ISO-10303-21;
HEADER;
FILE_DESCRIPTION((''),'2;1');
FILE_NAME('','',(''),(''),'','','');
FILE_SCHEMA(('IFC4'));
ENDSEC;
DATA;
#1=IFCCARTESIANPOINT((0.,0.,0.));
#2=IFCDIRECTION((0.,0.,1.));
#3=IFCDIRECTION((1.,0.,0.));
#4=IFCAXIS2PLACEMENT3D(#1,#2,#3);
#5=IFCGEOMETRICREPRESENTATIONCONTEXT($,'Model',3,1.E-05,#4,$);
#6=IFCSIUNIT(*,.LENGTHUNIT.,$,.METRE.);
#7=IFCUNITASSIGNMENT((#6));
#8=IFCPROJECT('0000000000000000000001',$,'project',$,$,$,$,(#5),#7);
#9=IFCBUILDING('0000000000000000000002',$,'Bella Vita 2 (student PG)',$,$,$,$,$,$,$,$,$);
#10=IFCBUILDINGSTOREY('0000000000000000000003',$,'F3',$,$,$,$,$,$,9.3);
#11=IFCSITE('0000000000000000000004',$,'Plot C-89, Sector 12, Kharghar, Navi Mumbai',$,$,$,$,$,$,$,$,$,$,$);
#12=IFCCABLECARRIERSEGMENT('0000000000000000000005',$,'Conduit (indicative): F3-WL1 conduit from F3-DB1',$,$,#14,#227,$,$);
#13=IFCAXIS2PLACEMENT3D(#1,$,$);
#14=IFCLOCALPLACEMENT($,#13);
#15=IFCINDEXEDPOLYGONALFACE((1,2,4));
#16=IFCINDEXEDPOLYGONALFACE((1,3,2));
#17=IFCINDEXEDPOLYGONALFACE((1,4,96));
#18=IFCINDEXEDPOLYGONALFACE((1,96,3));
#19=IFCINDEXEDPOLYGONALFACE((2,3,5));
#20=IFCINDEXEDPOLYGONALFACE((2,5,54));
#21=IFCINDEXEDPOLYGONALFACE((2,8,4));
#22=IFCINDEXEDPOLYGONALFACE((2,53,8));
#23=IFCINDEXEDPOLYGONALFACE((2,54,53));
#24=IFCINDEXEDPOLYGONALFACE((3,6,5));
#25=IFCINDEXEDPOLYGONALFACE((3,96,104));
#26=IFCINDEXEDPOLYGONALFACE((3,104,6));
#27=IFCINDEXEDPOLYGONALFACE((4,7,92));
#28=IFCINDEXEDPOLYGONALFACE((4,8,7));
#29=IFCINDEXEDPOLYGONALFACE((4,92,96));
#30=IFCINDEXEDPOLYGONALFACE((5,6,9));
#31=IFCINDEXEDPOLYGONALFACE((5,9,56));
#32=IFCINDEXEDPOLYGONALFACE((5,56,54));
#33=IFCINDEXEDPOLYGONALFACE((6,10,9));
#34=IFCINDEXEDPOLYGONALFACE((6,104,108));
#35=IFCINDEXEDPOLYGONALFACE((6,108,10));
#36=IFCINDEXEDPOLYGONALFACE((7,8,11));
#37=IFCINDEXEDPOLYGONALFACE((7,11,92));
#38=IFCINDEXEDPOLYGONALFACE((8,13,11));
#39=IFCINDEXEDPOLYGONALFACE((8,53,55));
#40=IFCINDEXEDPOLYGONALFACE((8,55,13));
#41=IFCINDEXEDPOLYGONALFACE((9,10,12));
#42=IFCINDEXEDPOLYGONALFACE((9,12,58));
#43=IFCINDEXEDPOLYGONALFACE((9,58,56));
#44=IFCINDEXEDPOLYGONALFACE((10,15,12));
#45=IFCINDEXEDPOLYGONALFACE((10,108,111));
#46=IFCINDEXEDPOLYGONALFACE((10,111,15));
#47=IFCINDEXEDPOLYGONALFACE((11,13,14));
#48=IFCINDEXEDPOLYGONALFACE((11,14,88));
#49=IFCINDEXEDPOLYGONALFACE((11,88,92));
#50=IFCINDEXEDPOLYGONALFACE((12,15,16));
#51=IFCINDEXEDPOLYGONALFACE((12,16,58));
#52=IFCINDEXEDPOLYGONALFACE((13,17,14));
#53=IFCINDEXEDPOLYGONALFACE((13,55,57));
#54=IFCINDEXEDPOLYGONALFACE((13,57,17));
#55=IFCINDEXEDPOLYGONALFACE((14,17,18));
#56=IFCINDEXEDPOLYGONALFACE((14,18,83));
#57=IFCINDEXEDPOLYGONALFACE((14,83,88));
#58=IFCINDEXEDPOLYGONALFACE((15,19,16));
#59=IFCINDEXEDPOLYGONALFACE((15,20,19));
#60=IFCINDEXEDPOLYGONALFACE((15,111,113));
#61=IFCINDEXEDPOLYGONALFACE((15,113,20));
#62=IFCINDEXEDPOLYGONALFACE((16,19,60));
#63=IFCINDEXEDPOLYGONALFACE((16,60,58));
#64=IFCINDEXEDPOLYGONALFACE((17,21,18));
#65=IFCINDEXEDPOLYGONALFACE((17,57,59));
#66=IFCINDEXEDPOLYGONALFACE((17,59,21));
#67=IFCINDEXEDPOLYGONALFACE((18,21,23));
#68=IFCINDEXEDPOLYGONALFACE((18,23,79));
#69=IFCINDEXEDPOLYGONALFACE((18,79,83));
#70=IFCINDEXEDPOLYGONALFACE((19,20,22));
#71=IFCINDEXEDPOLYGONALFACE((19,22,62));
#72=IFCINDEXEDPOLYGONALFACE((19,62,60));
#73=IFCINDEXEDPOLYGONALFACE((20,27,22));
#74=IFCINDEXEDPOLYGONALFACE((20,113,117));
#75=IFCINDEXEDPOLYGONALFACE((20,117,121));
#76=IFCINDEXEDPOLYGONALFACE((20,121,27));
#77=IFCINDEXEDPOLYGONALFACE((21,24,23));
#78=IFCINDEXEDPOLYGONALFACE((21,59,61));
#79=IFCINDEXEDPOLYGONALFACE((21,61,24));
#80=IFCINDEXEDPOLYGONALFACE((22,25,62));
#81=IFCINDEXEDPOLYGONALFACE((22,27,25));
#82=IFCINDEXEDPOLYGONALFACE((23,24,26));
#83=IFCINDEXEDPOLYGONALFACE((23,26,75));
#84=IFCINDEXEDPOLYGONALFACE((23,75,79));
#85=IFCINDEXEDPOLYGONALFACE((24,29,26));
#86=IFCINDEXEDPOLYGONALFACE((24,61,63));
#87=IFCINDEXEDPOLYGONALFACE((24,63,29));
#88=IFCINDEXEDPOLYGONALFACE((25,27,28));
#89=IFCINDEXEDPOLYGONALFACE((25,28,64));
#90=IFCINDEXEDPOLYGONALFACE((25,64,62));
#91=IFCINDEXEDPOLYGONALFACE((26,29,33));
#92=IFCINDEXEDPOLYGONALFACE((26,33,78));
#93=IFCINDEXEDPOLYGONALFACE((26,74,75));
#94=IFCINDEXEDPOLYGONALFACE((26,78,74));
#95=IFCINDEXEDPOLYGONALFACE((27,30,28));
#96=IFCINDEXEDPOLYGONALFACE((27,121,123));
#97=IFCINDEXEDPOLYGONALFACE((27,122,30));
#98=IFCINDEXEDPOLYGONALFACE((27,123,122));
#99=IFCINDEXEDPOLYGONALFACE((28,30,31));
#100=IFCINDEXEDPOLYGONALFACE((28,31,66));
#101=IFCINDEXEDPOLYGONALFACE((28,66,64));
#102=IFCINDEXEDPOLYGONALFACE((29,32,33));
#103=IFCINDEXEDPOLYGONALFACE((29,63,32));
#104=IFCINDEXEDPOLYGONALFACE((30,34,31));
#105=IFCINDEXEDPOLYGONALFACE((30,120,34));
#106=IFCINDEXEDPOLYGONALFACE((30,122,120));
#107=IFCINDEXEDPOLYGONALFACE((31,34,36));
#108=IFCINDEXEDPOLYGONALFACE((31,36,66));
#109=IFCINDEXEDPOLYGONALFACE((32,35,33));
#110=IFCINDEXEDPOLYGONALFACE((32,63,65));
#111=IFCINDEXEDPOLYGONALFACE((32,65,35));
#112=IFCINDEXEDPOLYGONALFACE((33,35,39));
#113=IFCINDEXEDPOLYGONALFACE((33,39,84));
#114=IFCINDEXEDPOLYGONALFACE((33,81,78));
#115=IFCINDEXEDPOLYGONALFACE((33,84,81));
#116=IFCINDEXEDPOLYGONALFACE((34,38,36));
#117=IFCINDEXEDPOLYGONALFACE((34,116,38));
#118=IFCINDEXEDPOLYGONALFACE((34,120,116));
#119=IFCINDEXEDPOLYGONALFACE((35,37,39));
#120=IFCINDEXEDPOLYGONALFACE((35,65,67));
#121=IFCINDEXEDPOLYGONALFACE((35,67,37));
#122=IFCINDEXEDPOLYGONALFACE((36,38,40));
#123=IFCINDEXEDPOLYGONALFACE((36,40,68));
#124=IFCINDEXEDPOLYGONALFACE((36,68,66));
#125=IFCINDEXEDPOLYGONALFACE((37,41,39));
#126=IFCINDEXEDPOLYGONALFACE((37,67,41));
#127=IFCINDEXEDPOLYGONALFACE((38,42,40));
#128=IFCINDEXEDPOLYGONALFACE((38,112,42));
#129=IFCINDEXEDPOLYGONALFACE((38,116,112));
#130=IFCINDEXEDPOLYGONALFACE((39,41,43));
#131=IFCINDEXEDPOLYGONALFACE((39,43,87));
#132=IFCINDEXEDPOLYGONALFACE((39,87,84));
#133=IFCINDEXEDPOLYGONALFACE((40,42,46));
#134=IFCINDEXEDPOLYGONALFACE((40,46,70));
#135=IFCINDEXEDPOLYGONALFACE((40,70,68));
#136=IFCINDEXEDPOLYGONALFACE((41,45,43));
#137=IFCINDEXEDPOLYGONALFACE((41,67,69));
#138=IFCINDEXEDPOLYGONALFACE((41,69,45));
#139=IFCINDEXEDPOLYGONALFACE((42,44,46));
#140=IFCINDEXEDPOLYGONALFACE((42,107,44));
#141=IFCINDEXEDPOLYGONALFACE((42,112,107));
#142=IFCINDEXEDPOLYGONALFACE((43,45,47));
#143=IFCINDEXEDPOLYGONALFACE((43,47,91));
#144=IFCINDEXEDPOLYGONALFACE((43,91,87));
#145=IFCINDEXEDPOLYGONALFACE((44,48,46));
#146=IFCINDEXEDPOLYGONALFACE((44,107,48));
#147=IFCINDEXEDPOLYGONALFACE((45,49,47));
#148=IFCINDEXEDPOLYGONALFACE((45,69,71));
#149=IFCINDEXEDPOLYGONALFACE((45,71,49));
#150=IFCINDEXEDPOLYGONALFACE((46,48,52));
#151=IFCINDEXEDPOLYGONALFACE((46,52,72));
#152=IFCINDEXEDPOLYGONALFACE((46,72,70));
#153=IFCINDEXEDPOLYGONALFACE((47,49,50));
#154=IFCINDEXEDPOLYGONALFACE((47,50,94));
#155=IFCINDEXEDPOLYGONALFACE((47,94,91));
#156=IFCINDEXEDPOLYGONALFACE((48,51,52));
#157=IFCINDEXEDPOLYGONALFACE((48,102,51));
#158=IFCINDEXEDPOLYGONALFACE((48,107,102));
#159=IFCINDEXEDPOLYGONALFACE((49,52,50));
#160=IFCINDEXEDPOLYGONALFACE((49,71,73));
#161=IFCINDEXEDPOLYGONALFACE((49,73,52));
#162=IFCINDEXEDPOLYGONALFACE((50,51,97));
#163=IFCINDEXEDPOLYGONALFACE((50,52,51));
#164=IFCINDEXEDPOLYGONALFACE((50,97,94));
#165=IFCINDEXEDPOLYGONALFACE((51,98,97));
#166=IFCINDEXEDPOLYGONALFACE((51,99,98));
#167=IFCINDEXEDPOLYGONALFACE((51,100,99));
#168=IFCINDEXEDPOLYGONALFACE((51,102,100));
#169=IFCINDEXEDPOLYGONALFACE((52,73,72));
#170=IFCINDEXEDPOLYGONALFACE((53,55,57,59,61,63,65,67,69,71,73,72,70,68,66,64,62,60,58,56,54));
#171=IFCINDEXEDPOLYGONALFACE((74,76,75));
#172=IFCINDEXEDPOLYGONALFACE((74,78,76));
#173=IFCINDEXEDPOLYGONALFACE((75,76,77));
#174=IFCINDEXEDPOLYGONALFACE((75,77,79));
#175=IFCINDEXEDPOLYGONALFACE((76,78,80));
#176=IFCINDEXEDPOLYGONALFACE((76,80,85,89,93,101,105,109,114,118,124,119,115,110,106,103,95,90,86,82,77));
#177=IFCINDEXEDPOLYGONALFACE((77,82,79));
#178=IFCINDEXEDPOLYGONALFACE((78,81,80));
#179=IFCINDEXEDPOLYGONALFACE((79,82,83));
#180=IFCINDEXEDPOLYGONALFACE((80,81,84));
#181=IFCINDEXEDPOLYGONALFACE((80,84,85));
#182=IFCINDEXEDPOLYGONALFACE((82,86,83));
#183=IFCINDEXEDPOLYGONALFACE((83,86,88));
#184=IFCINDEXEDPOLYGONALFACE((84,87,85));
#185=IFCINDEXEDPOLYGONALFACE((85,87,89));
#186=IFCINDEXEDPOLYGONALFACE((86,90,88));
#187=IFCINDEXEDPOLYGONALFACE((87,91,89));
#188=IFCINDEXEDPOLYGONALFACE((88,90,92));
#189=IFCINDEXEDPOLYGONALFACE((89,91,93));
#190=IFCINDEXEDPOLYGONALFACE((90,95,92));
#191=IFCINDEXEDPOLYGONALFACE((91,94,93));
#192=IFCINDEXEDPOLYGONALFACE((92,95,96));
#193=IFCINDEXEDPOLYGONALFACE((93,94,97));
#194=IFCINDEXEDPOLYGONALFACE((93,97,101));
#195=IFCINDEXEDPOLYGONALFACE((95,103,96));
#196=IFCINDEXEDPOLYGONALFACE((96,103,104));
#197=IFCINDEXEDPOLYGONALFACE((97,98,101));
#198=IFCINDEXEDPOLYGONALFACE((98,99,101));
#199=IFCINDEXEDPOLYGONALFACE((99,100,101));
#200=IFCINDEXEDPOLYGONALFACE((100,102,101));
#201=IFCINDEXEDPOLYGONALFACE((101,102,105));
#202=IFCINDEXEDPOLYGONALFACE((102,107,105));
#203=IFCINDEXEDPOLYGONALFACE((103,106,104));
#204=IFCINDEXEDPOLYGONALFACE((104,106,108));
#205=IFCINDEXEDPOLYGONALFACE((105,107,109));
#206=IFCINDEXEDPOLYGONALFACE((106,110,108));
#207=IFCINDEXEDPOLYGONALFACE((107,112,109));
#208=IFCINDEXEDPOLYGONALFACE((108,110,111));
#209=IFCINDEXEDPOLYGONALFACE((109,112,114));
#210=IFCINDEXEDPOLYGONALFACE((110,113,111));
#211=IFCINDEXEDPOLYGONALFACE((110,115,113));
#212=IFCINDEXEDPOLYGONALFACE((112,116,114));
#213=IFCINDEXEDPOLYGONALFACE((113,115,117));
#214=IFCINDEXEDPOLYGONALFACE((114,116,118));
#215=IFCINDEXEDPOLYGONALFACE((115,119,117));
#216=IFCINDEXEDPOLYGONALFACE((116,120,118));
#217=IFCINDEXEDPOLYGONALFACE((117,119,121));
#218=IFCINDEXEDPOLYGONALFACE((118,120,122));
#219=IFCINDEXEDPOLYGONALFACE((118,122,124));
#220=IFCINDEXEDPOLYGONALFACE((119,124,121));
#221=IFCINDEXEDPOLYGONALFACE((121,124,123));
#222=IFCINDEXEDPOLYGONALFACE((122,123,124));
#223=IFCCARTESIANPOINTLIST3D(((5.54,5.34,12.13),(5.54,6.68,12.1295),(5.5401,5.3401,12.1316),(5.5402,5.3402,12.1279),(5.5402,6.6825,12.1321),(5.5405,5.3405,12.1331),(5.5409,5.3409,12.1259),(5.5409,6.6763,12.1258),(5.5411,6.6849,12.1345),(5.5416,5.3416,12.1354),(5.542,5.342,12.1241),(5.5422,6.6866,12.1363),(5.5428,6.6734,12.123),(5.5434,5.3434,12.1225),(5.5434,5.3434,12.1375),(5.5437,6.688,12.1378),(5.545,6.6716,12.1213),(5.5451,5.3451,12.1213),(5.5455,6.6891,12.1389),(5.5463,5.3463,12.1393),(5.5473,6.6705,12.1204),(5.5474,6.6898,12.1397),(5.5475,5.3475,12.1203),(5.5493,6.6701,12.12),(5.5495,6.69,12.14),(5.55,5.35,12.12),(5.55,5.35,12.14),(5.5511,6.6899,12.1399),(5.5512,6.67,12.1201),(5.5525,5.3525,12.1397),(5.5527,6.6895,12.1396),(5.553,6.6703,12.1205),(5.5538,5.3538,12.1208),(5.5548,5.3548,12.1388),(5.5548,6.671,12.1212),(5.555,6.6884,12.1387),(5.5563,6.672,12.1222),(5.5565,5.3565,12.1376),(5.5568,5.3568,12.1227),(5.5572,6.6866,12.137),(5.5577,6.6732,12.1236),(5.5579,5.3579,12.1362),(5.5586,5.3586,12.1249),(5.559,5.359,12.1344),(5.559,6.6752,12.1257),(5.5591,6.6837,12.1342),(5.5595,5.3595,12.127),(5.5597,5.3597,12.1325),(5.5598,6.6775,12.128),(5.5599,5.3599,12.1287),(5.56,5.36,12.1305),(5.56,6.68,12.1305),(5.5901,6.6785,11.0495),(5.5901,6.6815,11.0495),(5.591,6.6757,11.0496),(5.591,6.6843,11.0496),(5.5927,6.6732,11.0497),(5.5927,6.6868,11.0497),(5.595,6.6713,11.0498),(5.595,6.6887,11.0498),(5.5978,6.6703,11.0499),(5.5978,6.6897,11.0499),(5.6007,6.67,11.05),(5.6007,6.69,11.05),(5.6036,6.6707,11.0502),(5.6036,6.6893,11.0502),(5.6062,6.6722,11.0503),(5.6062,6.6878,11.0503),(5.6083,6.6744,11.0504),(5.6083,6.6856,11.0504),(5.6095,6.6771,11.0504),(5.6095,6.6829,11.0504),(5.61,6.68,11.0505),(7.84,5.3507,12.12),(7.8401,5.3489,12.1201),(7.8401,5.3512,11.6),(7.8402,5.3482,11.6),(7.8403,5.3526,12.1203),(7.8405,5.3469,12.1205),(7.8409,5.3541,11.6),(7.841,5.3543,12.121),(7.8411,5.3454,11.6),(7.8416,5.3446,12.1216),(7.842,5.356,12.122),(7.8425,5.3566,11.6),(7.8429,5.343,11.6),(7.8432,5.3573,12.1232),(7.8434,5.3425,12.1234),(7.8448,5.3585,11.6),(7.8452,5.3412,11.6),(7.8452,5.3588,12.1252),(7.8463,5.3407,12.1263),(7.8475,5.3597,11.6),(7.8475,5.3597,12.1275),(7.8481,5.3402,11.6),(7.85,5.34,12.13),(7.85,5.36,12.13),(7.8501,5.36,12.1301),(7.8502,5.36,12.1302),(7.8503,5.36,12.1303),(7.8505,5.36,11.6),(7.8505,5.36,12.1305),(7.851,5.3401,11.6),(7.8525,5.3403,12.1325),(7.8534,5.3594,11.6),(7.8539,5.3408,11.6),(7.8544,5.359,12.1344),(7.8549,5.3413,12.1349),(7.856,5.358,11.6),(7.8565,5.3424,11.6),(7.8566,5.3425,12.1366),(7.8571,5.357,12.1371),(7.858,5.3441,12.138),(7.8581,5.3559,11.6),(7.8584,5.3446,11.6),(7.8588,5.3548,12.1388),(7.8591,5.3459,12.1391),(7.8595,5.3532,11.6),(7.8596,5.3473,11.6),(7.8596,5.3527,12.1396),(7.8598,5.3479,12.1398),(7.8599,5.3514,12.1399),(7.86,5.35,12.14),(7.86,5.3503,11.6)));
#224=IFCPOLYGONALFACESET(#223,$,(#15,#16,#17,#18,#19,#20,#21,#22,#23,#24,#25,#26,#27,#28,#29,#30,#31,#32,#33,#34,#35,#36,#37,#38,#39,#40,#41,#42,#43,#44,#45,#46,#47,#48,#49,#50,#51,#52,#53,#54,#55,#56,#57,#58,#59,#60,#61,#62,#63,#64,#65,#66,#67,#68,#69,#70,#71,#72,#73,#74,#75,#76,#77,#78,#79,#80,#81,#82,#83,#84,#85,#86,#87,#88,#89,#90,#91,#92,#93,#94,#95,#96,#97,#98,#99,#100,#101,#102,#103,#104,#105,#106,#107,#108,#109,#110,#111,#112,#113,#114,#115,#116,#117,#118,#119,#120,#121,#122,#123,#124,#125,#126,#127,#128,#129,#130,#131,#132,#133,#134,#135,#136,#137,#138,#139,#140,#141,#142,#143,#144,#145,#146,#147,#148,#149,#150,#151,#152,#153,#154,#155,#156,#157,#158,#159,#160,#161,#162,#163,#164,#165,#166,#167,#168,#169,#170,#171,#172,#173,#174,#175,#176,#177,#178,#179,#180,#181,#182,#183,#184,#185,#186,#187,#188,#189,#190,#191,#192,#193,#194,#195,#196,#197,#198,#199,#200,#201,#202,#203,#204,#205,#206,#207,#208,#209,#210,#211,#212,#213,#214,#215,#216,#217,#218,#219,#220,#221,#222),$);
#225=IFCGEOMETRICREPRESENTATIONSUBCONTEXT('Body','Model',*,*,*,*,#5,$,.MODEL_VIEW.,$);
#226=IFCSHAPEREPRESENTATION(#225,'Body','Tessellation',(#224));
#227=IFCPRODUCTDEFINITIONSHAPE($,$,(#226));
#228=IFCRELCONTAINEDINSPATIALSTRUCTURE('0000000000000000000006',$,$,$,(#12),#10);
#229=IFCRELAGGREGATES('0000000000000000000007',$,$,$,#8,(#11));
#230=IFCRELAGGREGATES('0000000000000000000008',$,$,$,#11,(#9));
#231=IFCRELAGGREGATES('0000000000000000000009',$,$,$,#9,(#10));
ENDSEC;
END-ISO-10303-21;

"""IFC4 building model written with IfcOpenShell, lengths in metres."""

from ifc_helpers import new_model, entity, si_unit, origin, origin_with_axes, place, context, subcontext, project, spatial, element, save


model = new_model("IFC4")

# Units and contexts
model_context = context("Model", 3, precision=1e-05, world=origin_with_axes())
body_context = subcontext(model_context, "Body", "Model", "MODEL_VIEW")
ifc_project = project(units=[si_unit("LENGTHUNIT", "METRE")], contexts=[model_context])

# Site, building, storey
site = spatial("IfcSite", under=ifc_project, Name="Plot C-89, Sector 12, Kharghar, Navi Mumbai")
building = spatial("IfcBuilding", under=site, Name="Bella Vita 2 (student PG)")
storey = spatial("IfcBuildingStorey", under=building, Name="F3", Elevation=9.3)

# Cable carrier segment
cable_carrier_segment_1_placement = place(None, origin())
element("IfcCableCarrierSegment", 1, at=cable_carrier_segment_1_placement, inside=storey, Name="Conduit (indicative): F3-WL1 conduit from F3-DB1", context=body_context, shape_type="AdvancedSweptSolid", body=[
    entity("IfcSweptDiskSolid", entity("IfcPolyline", [entity("IfcCartesianPoint", [5.6, 6.68, 11.05]), entity("IfcCartesianPoint", [5.55, 6.68, 12.13]), entity("IfcCartesianPoint", [5.55, 5.35, 12.13]), entity("IfcCartesianPoint", [7.85, 5.35, 12.13]), entity("IfcCartesianPoint", [7.85, 5.35, 11.6])]), 0.01),
])

save(model, "model.ifc")
